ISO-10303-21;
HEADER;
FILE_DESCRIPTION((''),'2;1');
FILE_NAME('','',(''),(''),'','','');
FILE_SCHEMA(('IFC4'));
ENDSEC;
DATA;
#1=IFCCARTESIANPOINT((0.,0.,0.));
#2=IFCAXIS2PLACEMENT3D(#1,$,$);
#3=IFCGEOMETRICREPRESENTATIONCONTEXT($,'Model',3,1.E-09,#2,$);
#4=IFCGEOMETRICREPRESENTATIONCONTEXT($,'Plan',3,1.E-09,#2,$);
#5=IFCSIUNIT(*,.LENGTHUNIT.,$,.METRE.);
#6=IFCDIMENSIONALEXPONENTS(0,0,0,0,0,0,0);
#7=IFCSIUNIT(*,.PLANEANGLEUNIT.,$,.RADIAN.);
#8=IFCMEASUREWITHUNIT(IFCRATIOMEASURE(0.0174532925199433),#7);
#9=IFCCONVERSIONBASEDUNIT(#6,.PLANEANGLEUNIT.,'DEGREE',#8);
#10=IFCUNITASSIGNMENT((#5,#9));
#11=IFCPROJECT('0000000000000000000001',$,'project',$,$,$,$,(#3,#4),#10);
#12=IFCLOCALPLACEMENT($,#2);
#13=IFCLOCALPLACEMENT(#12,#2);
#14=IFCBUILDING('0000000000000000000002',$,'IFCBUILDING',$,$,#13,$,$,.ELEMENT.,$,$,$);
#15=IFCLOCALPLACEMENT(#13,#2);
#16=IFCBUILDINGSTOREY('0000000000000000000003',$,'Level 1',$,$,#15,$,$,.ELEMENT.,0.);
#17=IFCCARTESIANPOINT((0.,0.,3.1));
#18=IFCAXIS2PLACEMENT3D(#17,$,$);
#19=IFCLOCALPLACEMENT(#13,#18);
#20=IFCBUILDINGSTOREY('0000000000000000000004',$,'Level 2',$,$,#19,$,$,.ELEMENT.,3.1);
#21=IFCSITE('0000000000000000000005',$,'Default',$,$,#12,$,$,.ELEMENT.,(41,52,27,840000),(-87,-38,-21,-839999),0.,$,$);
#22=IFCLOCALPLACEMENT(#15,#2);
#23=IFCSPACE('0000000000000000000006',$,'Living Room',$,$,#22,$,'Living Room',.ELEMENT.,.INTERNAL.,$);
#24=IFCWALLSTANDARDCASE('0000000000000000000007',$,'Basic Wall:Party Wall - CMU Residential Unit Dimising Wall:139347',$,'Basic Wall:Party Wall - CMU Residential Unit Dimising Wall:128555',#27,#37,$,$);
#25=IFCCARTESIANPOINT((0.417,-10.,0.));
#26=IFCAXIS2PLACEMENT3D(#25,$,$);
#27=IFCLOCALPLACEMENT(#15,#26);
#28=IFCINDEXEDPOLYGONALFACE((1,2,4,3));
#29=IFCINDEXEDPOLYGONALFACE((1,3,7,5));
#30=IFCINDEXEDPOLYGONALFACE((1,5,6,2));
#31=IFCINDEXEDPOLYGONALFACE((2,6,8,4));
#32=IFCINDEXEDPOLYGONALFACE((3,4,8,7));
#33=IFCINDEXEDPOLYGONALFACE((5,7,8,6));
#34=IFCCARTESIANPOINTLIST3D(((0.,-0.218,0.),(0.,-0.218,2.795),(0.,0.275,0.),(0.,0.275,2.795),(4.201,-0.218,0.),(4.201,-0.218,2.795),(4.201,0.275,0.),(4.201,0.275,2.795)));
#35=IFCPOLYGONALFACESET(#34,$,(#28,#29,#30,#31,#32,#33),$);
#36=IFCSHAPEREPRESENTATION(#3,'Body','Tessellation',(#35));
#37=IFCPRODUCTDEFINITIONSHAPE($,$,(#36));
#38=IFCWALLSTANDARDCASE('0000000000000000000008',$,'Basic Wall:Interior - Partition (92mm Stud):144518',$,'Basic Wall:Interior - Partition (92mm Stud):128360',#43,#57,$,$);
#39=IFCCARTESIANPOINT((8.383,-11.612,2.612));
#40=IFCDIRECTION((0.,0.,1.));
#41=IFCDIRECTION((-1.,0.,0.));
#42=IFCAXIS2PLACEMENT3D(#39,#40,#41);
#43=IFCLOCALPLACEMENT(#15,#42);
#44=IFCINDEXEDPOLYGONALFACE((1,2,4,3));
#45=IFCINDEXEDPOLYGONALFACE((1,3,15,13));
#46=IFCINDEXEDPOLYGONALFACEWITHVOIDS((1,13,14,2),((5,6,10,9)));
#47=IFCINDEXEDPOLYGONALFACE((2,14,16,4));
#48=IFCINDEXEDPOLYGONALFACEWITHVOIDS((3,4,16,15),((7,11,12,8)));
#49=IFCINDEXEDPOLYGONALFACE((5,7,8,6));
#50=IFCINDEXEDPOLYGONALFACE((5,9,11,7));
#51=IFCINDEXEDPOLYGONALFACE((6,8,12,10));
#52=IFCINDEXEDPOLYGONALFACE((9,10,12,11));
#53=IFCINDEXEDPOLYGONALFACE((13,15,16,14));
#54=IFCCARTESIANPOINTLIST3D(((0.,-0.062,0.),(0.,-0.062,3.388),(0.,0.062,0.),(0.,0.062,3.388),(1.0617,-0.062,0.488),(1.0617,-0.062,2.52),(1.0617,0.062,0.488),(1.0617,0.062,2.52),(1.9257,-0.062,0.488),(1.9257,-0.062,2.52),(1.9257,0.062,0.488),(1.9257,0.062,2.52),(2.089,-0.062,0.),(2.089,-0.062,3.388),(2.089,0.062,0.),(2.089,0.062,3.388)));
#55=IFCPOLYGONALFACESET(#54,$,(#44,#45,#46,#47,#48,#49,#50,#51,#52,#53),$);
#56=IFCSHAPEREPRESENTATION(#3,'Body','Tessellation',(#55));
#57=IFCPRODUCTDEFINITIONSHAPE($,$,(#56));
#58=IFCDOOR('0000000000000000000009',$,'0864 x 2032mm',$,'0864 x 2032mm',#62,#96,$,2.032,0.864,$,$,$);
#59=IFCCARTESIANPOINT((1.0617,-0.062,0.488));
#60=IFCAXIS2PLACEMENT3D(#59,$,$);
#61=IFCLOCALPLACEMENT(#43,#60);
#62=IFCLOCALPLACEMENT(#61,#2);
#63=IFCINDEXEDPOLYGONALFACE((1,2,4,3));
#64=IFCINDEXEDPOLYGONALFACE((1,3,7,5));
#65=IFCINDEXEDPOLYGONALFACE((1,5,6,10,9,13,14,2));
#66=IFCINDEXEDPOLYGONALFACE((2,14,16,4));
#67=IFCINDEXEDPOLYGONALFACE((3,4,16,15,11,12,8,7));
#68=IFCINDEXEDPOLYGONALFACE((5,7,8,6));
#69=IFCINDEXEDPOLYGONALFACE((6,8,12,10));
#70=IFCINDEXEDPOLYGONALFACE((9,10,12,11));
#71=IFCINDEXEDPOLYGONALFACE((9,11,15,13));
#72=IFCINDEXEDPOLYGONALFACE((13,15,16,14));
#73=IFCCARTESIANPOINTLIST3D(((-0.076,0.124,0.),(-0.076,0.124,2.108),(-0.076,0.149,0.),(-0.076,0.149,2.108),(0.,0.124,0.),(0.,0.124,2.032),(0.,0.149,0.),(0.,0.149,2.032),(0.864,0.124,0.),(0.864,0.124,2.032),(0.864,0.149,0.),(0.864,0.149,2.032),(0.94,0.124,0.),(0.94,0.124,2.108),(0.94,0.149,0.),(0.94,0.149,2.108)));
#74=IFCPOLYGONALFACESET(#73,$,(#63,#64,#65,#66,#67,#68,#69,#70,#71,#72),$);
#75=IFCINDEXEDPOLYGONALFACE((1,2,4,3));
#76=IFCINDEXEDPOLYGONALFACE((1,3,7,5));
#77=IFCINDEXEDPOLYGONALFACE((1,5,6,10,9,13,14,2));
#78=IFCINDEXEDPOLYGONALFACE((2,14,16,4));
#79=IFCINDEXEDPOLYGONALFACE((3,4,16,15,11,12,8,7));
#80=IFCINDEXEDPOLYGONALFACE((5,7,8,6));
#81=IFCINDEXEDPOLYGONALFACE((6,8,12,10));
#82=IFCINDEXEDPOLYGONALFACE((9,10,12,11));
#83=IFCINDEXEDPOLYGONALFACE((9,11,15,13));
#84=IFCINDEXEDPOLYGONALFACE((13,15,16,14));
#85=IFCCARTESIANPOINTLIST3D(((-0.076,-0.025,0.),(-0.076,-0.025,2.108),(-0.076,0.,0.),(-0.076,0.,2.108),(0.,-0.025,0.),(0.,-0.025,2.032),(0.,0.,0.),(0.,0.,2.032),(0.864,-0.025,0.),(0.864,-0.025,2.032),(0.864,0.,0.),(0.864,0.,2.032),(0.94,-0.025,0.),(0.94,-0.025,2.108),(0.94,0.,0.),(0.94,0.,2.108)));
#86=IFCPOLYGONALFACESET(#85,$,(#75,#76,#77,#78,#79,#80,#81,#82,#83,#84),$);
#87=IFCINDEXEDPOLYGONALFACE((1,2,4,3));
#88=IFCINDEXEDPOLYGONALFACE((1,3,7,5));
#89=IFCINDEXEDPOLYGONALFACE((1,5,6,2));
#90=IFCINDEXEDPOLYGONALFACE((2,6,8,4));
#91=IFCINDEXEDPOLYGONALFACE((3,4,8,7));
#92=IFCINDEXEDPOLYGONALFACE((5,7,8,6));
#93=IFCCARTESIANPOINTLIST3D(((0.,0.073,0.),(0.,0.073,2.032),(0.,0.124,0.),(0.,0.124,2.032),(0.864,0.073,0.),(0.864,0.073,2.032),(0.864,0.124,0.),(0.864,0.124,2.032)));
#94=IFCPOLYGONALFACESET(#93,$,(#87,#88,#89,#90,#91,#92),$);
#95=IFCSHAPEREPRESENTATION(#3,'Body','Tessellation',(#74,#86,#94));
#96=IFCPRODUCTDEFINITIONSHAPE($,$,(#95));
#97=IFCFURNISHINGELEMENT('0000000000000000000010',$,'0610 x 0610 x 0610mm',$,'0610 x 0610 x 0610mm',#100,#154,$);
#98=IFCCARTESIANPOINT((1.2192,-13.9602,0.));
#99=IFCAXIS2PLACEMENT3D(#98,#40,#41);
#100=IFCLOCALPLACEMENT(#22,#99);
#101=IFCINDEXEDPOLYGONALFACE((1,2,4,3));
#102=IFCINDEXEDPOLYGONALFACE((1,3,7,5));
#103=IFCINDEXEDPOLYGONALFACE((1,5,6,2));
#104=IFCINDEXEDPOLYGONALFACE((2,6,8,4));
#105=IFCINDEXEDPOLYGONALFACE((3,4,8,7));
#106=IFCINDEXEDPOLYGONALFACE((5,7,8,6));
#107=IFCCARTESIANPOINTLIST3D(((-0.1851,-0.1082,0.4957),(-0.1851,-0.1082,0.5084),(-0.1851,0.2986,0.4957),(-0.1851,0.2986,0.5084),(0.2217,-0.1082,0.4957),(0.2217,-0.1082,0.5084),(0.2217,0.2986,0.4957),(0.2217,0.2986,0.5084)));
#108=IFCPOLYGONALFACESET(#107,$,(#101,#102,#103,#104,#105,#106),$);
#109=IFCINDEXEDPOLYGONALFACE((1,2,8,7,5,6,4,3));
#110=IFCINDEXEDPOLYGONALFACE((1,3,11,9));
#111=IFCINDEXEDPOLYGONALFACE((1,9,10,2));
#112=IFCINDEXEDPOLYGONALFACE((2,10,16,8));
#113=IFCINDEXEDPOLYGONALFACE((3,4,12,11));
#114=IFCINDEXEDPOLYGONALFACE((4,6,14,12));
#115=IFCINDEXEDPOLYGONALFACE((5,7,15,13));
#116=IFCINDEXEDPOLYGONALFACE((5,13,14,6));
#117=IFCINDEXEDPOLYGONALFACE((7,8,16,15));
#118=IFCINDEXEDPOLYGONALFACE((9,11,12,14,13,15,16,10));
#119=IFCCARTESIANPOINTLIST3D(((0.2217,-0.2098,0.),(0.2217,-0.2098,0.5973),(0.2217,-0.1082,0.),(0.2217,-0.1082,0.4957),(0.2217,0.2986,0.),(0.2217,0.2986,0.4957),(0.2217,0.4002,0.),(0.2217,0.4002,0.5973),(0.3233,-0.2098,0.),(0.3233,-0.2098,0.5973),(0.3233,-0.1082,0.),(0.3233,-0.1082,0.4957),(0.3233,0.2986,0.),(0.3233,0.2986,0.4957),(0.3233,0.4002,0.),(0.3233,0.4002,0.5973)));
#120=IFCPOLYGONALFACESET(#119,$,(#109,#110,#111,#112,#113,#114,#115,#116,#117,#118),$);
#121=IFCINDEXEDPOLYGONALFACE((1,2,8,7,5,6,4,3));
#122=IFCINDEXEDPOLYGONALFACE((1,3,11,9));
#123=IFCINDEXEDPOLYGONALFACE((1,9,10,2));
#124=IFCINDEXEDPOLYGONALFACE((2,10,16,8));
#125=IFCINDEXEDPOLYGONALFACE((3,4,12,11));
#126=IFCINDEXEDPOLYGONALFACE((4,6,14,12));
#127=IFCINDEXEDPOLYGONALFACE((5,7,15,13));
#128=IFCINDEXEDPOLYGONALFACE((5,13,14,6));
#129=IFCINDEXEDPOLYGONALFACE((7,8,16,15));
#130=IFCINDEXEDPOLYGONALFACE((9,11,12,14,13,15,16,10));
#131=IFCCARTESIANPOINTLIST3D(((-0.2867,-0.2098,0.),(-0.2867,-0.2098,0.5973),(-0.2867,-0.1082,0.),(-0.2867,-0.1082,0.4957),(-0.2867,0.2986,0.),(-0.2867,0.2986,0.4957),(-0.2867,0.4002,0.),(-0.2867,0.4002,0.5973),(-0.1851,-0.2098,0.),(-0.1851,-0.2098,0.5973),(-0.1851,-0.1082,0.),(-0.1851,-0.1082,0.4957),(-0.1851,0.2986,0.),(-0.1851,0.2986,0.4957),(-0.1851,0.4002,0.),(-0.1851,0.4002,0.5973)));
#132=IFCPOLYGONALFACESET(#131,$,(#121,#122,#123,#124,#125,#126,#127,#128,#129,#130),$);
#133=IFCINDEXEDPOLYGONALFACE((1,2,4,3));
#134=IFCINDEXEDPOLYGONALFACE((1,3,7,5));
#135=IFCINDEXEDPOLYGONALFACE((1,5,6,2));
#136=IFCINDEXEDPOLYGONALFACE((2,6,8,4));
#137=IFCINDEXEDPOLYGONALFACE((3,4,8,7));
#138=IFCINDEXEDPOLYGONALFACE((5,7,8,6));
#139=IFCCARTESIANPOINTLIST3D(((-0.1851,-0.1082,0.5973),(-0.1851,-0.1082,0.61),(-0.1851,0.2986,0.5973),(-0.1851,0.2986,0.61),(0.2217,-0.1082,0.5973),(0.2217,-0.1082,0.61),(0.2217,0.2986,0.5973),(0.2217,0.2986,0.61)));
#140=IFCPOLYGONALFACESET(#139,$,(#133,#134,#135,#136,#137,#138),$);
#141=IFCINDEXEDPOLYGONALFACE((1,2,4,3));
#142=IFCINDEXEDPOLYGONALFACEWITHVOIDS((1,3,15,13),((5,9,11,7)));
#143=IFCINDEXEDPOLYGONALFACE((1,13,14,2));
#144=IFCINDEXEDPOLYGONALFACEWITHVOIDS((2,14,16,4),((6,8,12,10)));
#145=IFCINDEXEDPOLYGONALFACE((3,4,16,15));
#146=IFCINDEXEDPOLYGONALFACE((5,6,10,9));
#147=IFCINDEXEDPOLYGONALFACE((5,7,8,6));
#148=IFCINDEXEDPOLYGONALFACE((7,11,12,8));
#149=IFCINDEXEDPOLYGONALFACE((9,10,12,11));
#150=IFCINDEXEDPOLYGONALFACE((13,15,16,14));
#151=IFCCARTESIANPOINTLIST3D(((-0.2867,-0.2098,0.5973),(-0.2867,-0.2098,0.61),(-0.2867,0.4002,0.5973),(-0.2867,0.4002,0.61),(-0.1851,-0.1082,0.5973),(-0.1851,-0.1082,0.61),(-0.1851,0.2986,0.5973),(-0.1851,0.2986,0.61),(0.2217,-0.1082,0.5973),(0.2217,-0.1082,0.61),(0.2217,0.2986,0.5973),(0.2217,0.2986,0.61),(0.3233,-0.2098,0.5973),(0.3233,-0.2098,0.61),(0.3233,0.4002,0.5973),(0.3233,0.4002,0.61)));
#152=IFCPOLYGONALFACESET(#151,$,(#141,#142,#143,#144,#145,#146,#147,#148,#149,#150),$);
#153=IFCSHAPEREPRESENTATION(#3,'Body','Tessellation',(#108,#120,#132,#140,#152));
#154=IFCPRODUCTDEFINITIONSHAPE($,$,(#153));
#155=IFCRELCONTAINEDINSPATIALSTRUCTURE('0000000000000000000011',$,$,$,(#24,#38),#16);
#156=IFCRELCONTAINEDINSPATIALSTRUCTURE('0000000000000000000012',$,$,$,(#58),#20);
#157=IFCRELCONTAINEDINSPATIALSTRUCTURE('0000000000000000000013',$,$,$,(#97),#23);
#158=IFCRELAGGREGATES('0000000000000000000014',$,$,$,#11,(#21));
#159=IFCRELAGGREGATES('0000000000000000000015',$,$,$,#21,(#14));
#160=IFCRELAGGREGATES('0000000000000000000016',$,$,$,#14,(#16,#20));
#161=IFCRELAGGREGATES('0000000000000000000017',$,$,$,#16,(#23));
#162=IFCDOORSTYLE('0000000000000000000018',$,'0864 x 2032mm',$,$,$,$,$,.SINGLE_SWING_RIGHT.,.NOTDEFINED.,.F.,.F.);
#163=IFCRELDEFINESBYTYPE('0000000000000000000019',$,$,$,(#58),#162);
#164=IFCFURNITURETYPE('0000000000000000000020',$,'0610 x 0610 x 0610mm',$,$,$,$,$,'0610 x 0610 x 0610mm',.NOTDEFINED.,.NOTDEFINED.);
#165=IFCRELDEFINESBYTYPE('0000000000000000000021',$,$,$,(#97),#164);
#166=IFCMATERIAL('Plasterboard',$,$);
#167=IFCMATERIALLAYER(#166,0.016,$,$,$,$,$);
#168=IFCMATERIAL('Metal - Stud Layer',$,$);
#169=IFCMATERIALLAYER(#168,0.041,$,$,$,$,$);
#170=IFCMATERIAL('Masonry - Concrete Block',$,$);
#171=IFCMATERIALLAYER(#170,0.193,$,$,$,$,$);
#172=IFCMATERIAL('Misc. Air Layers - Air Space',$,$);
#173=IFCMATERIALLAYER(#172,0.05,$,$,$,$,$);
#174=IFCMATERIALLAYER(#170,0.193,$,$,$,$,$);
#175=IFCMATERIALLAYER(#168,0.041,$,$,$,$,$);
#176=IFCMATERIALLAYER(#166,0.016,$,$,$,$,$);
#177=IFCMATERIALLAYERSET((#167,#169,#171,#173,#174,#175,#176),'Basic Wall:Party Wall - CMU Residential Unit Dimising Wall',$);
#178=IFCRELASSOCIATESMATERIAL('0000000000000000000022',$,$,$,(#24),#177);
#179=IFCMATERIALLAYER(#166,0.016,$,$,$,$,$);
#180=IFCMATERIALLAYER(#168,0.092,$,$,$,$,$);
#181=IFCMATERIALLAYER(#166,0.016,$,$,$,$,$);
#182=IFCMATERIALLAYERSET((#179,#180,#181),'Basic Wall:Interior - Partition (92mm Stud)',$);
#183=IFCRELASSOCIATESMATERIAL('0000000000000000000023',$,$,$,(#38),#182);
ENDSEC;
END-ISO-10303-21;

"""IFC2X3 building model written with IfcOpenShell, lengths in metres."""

from ifc_helpers import new_model, entity, si_unit, converted_unit, frame, frame_2d, origin, origin_2d_with_axis, place, context, project, spatial, polyline, rectangle, outline, extrude, clip, bounded_halfspace, source, transform, mapped, material, layer, layer_set, layer_usage, type_object, type_shapes, element, fill, save


model = new_model("IFC2X3")

# Units and contexts
model_context = context("Model", 3, precision=1e-09, world=origin())
plan_context = context("Plan", 3, precision=1e-09, world=origin())
ifc_project = project(units=[si_unit("LENGTHUNIT", "METRE"), converted_unit("PLANEANGLEUNIT", "DEGREE", entity("IfcRatioMeasure", 0.0174532925199433), si_unit("PLANEANGLEUNIT", "RADIAN"), dimensions=[0, 0, 0, 0, 0, 0, 0])], contexts=[model_context, plan_context])

# Site, building, storey
site_placement = place(None, origin())
site = spatial("IfcSite", under=ifc_project, at=site_placement, Name="Default", CompositionType="ELEMENT", RefLatitude=(41, 52, 27, 840000), RefLongitude=(-87, -38, -21, -839999), RefElevation=0.0)
building_placement = place(site_placement, origin())
building = spatial("IfcBuilding", under=site, at=building_placement, Name="IFCBUILDING", CompositionType="ELEMENT")
storey_1_placement = place(building_placement, origin())
storey_1 = spatial("IfcBuildingStorey", under=building, at=storey_1_placement, Name="Level 1", CompositionType="ELEMENT", Elevation=0.0)

# Shared definitions
ifc_material_1 = material(Name="Misc. Air Layers - Air Space")
ifc_material_2 = material(Name="Masonry - Concrete Block")
ifc_material_3 = material(Name="Metal - Stud Layer")
ifc_material_4 = material(Name="Plasterboard")

# Wall
ifc_layer_1 = layer(ifc_material_4, 0.016)
ifc_layer_2 = layer(ifc_material_3, 0.041)
ifc_layer_3 = layer(ifc_material_2, 0.193)
ifc_layer_4 = layer(ifc_material_1, 0.05)
ifc_layer_5 = layer(ifc_material_2, 0.193)
ifc_layer_6 = layer(ifc_material_3, 0.041)
ifc_layer_7 = layer(ifc_material_4, 0.016)
ifc_layer_set_1 = layer_set([ifc_layer_1, ifc_layer_2, ifc_layer_3, ifc_layer_4, ifc_layer_5, ifc_layer_6, ifc_layer_7], Name="Basic Wall:Party Wall - CMU Residential Unit Dimising Wall")
ifc_layer_usage_1 = layer_usage(ifc_layer_set_1, "AXIS2", "NEGATIVE", 0.275)
wall_1_placement = place(storey_1_placement, frame((0.417, -10.0, 0.0)))
element("IfcWallStandardCase", 1, at=wall_1_placement, inside=storey_1, material=ifc_layer_usage_1, Name="Basic Wall:Party Wall - CMU Residential Unit Dimising Wall:139347", ObjectType="Basic Wall:Party Wall - CMU Residential Unit Dimising Wall:128555", context=model_context, shape_type="Clipping", body=[
    clip(clip(extrude(rectangle(XDim=4.201, YDim=0.55, at=frame_2d((2.1005, 0.0), x_axis=(-1.0, 0.0))), origin(), (0.0, 0.0, 1.0), 2.795), bounded_halfspace(frame((0.0, -0.218, 0.0), z_axis=(0.0, 1.0, 0.0), x_axis=(-1.0, 0.0, 0.0)), True, frame((0.0, -0.218, 0.0), z_axis=(0.0, 1.0, 0.0), x_axis=(-1.0, 0.0, 0.0)), polyline([(0.0, 0.0), (0.0, 2.795), (-4.201, 2.795), (-4.201, 0.0), (0.0, 0.0)]))), bounded_halfspace(frame((4.201, 0.275, 0.0), z_axis=(-1.0, 0.0, 0.0), x_axis=(0.0, -1.0, 0.0)), True, frame((4.201, 0.275, 0.0), z_axis=(-1.0, 0.0, 0.0), x_axis=(0.0, -1.0, 0.0)), polyline([(0.0, 0.0), (0.493, 0.0), (0.493, 2.795), (0.0, 2.795), (0.0, 0.0)]))),
])

# Shared definitions
ifc_layer_8 = layer(ifc_material_4, 0.016)
ifc_layer_9 = layer(ifc_material_3, 0.092)
ifc_layer_10 = layer(ifc_material_4, 0.016)
ifc_layer_set_2 = layer_set([ifc_layer_8, ifc_layer_9, ifc_layer_10], Name="Basic Wall:Interior - Partition (92mm Stud)")

# Wall, opening
ifc_layer_usage_2 = layer_usage(ifc_layer_set_2, "AXIS2", "NEGATIVE", 0.062)
wall_2_placement = place(storey_1_placement, frame((8.383, -11.612, 2.612), z_axis=(0.0, 0.0, 1.0), x_axis=(-1.0, 0.0, 0.0)))
wall_2 = element("IfcWallStandardCase", 2, at=wall_2_placement, inside=storey_1, material=ifc_layer_usage_2, Name="Basic Wall:Interior - Partition (92mm Stud):144518", ObjectType="Basic Wall:Interior - Partition (92mm Stud):128360", context=model_context, shape_type="SweptSolid", body=[
    extrude(rectangle(XDim=2.089, YDim=0.124, at=frame_2d((1.0445, 0.0), x_axis=(-1.0, 0.0))), origin(), (0.0, 0.0, 1.0), 3.388),
])
opening_1_placement = place(wall_2_placement, frame((1.0617, -0.062, 0.488)))
opening_1 = element("IfcOpeningElement", 3, at=opening_1_placement, cuts=wall_2, ObjectType="Opening", context=model_context, shape_type="SweptSolid", body=[
    extrude(rectangle(XDim=0.864, YDim=2.032, at=frame_2d((1.016, 0.432), x_axis=(0.0, 1.0))), frame((0.0, 0.0, 0.0), z_axis=(0.0, 1.0, 0.0), x_axis=(0.0, 0.0, 1.0)), (0.0, 0.0, 1.0), 0.124),
])

# Shared definitions
storey_2_placement = place(building_placement, frame((0.0, 0.0, 3.1)))
storey_2 = spatial("IfcBuildingStorey", under=building, at=storey_2_placement, Name="Level 2", CompositionType="ELEMENT", Elevation=3.1)

# Door
door_style_1 = type_object("IfcDoorStyle", Name="0864 x 2032mm", ConstructionType="NOTDEFINED", OperationType="SINGLE_SWING_RIGHT", ParameterTakesPrecedence=False, Sizeable=False)
shared_shape_1 = source(origin(), model_context, "Body", "SweptSolid", [
    extrude(outline(polyline([(-0.508, -1.073), (0.508, -1.073), (0.508, 1.035), (0.432, 1.035), (0.432, -0.997), (-0.432, -0.997), (-0.432, 1.035), (-0.508, 1.035), (-0.508, -1.073)])), frame((0.432, 0.124, 1.035), z_axis=(0.0, 1.0, 0.0), x_axis=(1.0, 0.0, 0.0)), (0.0, 0.0, 1.0), 0.025),
    extrude(outline(polyline([(-1.073, -0.508), (1.035, -0.508), (1.035, -0.432), (-0.997, -0.432), (-0.997, 0.432), (1.035, 0.432), (1.035, 0.508), (-1.073, 0.508), (-1.073, -0.508)])), frame((0.432, -0.025, 1.035), z_axis=(0.0, 1.0, 0.0), x_axis=(0.0, 0.0, -1.0)), (0.0, 0.0, 1.0), 0.025),
    extrude(rectangle(XDim=0.051, YDim=0.864, at=origin_2d_with_axis()), frame((0.432, 0.0985, 0.0), z_axis=(0.0, 0.0, 1.0), x_axis=(0.0, 1.0, 0.0)), (0.0, 0.0, 1.0), 2.032),
])
type_shapes(door_style_1, [shared_shape_1])
door_1_placement = place(opening_1_placement, origin())
door_1 = element("IfcDoor", 4, at=door_1_placement, inside=storey_2, type_object=door_style_1, Name="0864 x 2032mm", ObjectType="0864 x 2032mm", OverallHeight=2.032, OverallWidth=0.864, context=model_context, shape_type="MappedRepresentation", body=[
    mapped(shared_shape_1, transform((0.0, 0.0, 0.0), scale=1.0)),
])
fill(opening_1, door_1)

# Shared definitions
space_1_placement = place(storey_1_placement, origin())
space_1 = spatial("IfcSpace", under=storey_1, at=space_1_placement, Name="Living Room", LongName="Living Room", CompositionType="ELEMENT", InteriorOrExteriorSpace="INTERNAL")

# Furnishing element
furniture_type_1 = type_object("IfcFurnitureType", Name="0610 x 0610 x 0610mm", ElementType="0610 x 0610 x 0610mm", AssemblyPlace="NOTDEFINED")
shared_shape_2 = source(origin(), model_context, "Body", "SweptSolid", [
    extrude(rectangle(XDim=0.4068, YDim=0.4068, at=origin_2d_with_axis()), frame((0.0183, 0.0952, 0.4957), z_axis=(0.0, 0.0, 1.0), x_axis=(-1.0, 0.0, 0.0)), (0.0, 0.0, 1.0), 0.0127),
    extrude(outline(polyline([(-0.2732, -0.305), (0.324, -0.305), (0.324, 0.305), (-0.2732, 0.305), (-0.2732, 0.2034), (0.2225, 0.2034), (0.2225, -0.2034), (-0.2732, -0.2034), (-0.2732, -0.305)])), frame((0.2217, 0.0952, 0.2732), z_axis=(1.0, 0.0, 0.0), x_axis=(0.0, 0.0, 1.0)), (0.0, 0.0, 1.0), 0.1016),
    extrude(outline(polyline([(-0.305, -0.3241), (0.305, -0.3241), (0.305, 0.2733), (0.2034, 0.2733), (0.2034, -0.2224), (-0.2034, -0.2224), (-0.2034, 0.2733), (-0.305, 0.2733), (-0.305, -0.3241)])), frame((-0.2867, 0.0952, 0.2733), z_axis=(1.0, 0.0, 0.0), x_axis=(0.0, -1.0, 0.0)), (0.0, 0.0, 1.0), 0.1016),
    extrude(rectangle(XDim=0.4068, YDim=0.4068, at=origin_2d_with_axis()), frame((0.0183, 0.0952, 0.5973), z_axis=(0.0, 0.0, 1.0), x_axis=(-1.0, 0.0, 0.0)), (0.0, 0.0, 1.0), 0.0127),
    extrude(outline(polyline([(-0.305, -0.305), (0.305, -0.305), (0.305, 0.305), (-0.305, 0.305), (-0.305, -0.305)]), holes=[polyline([(-0.2034, -0.2034), (-0.2034, 0.2034), (0.2034, 0.2034), (0.2034, -0.2034), (-0.2034, -0.2034)])]), frame((0.0183, 0.0952, 0.5973), z_axis=(0.0, 0.0, 1.0), x_axis=(-1.0, 0.0, 0.0)), (0.0, 0.0, 1.0), 0.0127),
])
type_shapes(furniture_type_1, [shared_shape_2])
for number, where, z_axis, x_axis, name in (
    (5, (1.2192, -13.9602, 0.0), (0.0, 0.0, 1.0), (-1.0, 0.0, 0.0), "0610 x 0610 x 0610mm"),
):
    element("IfcFurnishingElement", number, at=place(space_1_placement, frame(where, z_axis=z_axis, x_axis=x_axis)), inside=space_1, type_object=furniture_type_1, Name=name, ObjectType="0610 x 0610 x 0610mm", context=model_context, shape_type="MappedRepresentation", body=[
        mapped(shared_shape_2, transform((0.0, 0.0, 0.0), scale=1.0)),
    ])

save(model, "model.ifc")
